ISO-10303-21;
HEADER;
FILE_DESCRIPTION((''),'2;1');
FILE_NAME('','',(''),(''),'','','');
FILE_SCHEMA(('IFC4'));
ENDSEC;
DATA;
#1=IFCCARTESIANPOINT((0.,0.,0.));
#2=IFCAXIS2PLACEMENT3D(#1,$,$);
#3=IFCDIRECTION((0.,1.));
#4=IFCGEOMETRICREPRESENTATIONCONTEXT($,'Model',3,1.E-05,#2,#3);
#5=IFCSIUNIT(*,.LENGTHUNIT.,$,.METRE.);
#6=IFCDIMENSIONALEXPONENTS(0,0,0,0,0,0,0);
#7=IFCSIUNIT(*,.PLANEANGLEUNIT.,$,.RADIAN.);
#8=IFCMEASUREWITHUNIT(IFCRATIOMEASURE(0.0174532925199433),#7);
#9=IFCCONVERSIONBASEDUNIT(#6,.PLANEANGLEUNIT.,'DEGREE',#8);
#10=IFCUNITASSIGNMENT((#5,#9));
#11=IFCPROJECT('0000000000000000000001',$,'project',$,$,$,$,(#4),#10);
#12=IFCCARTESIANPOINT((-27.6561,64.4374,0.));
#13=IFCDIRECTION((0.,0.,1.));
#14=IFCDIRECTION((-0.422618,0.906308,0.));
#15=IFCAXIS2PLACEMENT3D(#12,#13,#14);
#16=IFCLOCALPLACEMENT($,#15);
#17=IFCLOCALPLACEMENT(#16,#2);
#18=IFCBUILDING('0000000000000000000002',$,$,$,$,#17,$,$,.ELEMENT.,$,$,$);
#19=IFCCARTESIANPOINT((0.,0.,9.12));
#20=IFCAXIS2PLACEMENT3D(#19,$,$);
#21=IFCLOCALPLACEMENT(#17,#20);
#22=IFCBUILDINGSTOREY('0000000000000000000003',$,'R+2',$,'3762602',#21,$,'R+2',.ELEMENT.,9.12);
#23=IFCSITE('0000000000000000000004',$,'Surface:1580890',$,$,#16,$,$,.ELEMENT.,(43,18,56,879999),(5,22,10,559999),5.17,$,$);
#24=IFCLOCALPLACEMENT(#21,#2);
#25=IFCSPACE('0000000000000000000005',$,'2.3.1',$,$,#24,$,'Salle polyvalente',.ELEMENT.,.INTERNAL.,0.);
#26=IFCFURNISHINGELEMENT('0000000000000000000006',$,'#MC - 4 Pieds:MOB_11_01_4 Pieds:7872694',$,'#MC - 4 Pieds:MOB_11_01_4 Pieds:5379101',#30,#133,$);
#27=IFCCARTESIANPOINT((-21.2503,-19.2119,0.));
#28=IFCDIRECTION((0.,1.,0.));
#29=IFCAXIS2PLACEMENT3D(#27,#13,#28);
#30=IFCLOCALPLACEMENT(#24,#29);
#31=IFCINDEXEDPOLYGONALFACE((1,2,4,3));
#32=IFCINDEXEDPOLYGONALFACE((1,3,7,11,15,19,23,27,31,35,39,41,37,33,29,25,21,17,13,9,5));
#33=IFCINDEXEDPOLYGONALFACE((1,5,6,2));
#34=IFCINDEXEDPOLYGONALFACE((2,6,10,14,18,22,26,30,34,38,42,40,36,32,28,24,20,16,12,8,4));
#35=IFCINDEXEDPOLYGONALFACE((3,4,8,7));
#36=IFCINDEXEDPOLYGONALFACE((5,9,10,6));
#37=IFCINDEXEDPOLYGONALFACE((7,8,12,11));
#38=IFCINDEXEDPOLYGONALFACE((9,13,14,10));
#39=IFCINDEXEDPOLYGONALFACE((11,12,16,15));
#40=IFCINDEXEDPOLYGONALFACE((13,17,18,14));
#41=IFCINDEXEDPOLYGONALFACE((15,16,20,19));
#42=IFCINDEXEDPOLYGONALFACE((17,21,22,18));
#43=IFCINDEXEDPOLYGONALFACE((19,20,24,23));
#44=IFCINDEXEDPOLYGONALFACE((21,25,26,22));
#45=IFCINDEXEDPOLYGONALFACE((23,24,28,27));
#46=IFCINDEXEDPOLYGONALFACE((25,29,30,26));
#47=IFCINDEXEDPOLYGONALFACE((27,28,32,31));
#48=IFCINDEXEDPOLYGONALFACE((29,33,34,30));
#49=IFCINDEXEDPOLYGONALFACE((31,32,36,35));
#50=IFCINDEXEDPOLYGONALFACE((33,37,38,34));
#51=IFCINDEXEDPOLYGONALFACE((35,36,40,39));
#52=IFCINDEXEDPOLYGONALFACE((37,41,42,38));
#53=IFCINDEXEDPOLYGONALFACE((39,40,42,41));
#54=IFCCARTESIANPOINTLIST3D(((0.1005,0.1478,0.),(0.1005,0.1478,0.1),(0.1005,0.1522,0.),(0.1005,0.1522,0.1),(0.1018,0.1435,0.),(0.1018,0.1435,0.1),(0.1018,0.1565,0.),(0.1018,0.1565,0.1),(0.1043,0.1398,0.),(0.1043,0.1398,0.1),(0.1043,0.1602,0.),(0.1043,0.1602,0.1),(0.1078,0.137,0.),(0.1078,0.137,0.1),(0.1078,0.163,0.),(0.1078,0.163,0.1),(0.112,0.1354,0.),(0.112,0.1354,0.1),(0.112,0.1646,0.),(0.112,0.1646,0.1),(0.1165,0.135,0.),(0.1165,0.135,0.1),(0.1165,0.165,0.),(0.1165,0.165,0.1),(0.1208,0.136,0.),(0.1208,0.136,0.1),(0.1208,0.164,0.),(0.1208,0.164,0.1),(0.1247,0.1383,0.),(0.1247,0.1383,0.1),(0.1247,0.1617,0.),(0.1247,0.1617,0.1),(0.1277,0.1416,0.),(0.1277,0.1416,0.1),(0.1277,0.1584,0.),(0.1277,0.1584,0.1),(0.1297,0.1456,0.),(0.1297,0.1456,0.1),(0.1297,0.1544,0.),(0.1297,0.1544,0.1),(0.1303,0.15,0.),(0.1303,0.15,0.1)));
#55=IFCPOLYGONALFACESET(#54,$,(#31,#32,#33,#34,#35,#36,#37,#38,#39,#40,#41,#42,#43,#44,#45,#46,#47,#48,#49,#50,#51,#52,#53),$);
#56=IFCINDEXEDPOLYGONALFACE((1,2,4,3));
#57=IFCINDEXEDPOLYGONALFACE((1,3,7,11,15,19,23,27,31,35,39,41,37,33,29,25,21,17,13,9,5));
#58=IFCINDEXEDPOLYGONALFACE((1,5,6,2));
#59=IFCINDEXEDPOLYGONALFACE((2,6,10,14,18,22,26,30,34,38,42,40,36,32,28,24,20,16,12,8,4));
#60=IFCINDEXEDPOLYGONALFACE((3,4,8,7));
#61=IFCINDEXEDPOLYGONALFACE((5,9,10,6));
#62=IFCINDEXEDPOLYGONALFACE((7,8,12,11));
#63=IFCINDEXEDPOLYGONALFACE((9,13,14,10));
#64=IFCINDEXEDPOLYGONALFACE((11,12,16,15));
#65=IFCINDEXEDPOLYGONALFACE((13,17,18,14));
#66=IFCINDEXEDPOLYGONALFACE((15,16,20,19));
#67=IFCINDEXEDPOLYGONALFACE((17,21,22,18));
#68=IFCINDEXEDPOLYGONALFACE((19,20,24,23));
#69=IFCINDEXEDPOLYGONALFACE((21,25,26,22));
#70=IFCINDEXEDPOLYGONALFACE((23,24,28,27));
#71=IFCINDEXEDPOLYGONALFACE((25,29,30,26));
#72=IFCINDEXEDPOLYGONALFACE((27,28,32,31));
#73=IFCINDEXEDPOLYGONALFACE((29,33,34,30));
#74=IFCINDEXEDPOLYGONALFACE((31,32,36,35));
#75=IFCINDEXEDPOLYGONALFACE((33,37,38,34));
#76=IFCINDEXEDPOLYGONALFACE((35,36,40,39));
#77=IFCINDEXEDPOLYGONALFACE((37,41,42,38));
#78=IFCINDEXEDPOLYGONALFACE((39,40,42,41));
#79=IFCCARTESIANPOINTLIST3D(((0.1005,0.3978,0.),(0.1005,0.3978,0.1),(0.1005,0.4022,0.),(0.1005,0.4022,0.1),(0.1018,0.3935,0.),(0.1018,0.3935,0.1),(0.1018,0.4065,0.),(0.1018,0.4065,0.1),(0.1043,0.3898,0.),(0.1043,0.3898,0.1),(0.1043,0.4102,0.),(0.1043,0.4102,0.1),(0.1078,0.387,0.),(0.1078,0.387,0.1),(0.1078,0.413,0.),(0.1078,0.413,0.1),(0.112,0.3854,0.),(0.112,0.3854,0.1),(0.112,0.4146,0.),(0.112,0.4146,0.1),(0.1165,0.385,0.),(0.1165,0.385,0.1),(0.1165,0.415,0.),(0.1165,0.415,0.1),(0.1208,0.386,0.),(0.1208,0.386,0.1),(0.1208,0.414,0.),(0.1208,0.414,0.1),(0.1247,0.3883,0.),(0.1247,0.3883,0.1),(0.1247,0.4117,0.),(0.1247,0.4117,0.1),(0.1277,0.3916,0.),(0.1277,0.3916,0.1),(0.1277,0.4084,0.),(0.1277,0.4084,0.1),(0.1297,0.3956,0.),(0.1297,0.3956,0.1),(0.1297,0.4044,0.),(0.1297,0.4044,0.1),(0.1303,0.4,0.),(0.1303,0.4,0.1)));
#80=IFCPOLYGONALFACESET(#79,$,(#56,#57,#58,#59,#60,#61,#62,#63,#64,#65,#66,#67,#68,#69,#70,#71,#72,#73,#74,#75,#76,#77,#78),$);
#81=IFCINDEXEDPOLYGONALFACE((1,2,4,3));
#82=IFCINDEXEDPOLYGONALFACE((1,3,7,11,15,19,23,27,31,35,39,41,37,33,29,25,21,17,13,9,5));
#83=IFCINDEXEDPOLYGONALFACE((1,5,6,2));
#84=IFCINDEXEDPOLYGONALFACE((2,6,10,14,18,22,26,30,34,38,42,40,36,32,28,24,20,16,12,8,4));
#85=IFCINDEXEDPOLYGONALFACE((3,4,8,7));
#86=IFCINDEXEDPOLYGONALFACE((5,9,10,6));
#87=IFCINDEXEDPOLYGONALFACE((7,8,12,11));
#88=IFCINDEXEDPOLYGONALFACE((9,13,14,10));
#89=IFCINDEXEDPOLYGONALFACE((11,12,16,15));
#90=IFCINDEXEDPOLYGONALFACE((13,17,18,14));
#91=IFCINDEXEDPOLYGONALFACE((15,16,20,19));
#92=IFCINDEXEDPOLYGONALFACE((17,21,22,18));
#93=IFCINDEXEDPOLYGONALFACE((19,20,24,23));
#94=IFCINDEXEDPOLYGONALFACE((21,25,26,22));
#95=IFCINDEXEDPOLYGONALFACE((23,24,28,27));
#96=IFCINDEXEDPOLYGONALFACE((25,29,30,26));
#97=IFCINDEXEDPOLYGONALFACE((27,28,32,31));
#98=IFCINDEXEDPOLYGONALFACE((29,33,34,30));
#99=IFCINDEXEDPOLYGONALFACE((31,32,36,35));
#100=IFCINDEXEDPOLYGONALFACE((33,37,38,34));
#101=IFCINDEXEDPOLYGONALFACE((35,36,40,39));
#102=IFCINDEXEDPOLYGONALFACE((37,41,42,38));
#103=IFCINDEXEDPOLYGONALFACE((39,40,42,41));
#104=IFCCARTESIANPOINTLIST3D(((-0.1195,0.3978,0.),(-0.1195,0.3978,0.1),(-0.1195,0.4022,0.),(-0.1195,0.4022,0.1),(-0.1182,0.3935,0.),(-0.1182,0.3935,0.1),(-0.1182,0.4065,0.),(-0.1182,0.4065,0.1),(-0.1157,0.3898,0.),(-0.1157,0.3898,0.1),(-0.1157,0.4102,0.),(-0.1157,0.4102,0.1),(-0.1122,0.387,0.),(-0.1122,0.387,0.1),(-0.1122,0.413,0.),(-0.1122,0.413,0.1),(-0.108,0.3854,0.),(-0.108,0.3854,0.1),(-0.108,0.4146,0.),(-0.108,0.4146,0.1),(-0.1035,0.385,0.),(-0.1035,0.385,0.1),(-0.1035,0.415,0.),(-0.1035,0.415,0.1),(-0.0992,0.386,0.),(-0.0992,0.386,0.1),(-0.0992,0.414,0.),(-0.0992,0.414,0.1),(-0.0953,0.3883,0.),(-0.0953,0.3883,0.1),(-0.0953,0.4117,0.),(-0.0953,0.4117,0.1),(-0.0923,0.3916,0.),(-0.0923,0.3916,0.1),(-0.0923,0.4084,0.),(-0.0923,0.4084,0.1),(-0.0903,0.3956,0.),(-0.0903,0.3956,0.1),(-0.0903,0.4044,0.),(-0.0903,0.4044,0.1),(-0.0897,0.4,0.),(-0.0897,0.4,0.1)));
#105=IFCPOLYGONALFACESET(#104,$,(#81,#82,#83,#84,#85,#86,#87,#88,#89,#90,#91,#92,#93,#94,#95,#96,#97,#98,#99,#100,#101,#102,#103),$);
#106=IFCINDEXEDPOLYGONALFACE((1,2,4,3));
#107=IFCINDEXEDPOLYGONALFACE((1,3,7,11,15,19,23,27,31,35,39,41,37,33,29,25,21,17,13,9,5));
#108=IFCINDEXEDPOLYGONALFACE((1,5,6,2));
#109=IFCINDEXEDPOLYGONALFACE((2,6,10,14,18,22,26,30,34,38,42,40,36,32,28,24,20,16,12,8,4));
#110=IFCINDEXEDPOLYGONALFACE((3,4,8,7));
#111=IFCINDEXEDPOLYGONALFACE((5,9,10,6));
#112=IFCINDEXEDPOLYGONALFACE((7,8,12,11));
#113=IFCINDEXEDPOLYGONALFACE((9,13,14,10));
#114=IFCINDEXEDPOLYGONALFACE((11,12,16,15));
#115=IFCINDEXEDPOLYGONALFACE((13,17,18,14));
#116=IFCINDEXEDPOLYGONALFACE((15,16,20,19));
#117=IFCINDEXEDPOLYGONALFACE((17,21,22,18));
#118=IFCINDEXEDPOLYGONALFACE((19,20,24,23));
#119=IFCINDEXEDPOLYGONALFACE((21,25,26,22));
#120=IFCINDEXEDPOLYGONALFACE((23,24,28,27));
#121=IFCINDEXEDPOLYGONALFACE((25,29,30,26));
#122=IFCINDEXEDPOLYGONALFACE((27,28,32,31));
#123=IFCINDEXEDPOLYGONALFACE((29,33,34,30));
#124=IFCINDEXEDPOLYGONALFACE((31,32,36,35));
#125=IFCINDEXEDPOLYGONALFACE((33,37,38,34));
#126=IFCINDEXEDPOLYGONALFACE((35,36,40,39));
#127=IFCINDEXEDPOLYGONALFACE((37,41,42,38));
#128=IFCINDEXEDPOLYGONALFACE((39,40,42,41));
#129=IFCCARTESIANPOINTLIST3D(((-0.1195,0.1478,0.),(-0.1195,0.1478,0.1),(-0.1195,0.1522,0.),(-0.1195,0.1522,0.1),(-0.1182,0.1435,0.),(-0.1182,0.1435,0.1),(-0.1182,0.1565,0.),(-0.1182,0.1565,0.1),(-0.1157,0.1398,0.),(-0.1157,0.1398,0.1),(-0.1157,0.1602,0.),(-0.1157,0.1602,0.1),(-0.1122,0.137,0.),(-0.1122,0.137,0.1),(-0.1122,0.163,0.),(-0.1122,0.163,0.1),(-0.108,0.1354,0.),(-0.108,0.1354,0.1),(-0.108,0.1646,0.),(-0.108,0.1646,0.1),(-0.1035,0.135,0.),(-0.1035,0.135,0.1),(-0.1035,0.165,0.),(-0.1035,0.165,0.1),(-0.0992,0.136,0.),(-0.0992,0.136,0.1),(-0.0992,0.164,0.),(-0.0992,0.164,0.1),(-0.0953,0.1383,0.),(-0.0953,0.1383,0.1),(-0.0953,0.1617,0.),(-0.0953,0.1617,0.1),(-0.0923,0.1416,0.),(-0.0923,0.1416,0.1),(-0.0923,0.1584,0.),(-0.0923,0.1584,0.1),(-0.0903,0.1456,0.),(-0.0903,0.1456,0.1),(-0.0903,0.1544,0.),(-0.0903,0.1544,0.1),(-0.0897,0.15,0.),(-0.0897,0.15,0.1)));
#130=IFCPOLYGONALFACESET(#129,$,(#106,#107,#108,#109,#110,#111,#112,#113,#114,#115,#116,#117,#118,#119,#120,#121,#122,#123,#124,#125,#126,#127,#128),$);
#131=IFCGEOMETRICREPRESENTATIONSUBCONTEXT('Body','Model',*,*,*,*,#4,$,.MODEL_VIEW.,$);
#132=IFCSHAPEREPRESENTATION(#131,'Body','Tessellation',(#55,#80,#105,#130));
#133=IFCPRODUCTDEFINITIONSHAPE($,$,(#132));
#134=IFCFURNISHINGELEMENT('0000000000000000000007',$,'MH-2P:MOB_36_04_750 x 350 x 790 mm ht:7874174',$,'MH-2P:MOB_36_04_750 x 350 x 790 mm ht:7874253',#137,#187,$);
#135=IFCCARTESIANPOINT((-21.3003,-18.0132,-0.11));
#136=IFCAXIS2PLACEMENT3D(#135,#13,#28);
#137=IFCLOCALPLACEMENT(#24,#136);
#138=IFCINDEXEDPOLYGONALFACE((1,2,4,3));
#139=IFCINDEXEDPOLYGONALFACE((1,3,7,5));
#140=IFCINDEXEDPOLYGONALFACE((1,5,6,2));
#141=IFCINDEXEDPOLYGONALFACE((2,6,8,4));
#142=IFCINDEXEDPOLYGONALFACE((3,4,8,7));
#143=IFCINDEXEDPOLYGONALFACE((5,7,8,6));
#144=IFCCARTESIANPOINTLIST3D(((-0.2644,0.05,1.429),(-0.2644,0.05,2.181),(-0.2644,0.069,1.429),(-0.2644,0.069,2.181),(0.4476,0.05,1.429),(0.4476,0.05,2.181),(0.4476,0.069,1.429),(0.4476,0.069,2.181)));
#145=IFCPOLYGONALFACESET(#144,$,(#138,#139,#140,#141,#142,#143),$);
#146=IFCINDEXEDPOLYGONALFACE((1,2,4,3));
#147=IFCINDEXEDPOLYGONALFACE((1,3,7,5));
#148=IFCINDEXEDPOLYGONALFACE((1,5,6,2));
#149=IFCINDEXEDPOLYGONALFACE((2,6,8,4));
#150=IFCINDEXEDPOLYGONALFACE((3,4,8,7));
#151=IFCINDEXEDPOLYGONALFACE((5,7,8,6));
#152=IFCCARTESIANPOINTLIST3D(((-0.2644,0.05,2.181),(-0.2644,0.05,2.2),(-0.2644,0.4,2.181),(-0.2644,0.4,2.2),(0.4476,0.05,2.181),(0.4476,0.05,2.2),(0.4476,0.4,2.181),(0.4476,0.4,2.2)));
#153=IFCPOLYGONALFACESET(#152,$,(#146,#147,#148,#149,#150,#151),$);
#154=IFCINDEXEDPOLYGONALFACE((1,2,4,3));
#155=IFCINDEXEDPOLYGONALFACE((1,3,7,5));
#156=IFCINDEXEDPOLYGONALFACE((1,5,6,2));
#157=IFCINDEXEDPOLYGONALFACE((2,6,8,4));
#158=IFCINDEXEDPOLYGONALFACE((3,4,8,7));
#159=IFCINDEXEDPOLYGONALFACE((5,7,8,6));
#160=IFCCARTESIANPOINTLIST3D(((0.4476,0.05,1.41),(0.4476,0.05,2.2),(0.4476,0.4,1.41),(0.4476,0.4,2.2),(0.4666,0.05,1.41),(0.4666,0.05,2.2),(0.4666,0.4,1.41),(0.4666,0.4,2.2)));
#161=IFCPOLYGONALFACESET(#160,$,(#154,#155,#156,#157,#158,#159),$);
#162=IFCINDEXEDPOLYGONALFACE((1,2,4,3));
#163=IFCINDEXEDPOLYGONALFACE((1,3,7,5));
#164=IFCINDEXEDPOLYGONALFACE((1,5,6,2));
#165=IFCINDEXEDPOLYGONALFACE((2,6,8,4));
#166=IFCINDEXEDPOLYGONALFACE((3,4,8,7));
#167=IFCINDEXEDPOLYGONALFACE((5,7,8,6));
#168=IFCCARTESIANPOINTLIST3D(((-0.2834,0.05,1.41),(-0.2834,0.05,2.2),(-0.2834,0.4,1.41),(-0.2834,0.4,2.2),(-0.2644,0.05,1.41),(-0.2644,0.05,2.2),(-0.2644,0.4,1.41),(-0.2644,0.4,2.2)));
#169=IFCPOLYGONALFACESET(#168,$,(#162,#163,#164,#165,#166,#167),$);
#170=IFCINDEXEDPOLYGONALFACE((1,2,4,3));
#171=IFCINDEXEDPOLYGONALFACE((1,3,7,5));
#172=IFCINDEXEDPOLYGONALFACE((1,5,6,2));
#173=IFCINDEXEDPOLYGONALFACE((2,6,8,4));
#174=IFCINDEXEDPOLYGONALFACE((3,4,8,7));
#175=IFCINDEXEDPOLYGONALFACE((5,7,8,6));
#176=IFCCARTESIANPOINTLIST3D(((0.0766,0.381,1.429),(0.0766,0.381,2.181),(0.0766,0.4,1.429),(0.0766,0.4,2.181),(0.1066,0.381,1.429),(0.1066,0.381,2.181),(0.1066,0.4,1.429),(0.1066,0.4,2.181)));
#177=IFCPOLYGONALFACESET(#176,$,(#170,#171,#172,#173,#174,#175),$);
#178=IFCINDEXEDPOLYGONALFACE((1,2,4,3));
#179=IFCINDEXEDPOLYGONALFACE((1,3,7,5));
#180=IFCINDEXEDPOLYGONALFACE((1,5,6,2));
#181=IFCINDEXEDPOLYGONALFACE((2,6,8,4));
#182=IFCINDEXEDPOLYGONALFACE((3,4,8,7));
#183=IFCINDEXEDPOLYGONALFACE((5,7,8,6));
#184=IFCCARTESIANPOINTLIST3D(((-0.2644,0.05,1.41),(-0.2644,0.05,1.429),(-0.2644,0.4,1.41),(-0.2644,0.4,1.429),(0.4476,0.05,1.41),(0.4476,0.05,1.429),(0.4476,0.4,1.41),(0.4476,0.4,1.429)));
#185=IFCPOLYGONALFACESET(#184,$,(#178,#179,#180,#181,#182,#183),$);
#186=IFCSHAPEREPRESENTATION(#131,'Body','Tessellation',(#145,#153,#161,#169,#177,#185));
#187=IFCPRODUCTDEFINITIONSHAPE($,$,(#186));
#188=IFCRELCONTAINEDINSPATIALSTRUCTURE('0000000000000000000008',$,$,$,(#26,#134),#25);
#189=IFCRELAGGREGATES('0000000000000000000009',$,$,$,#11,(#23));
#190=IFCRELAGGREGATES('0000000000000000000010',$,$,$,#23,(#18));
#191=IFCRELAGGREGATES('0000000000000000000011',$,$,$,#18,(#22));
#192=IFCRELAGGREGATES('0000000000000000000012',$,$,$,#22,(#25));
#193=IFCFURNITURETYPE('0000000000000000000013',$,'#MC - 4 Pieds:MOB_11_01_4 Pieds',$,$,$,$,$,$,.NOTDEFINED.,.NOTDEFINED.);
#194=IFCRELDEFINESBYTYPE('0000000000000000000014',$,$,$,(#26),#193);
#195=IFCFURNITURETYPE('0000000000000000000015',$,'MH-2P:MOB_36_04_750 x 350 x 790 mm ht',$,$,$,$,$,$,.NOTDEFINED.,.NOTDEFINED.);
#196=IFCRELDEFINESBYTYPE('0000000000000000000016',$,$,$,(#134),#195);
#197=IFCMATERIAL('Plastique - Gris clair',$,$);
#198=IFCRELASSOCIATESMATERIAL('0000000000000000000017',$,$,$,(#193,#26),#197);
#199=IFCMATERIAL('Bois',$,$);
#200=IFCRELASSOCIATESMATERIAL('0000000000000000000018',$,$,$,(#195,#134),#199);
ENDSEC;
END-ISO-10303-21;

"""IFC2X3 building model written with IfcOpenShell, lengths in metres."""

from ifc_helpers import new_model, entity, si_unit, converted_unit, direction, frame, frame_2d, origin, origin_2d_with_axis, place, context, subcontext, project, spatial, rectangle, circle, extrude, source, transform, mapped, material, type_object, type_shapes, element, save


model = new_model("IFC2X3")

# Units and contexts
model_context = context("Model", 3, precision=1e-05, world=origin(), true_north=direction((0.0, 1.0)))
body_context = subcontext(model_context, "Body", "Model", "MODEL_VIEW")
ifc_project = project(units=[si_unit("LENGTHUNIT", "METRE"), converted_unit("PLANEANGLEUNIT", "DEGREE", entity("IfcRatioMeasure", 0.0174532925199433), si_unit("PLANEANGLEUNIT", "RADIAN"), dimensions=[0, 0, 0, 0, 0, 0, 0])], contexts=[model_context])

# Site, building, storey
site_placement = place(None, frame((-27.6561, 64.4374, 0.0), z_axis=(0.0, 0.0, 1.0), x_axis=(-0.422618, 0.906308, 0.0)))
site = spatial("IfcSite", under=ifc_project, at=site_placement, Name="Surface:1580890", CompositionType="ELEMENT", RefLatitude=(43, 18, 56, 879999), RefLongitude=(5, 22, 10, 559999), RefElevation=5.17)
building_placement = place(site_placement, origin())
building = spatial("IfcBuilding", under=site, at=building_placement, CompositionType="ELEMENT")
storey_placement = place(building_placement, frame((0.0, 0.0, 9.12)))
storey = spatial("IfcBuildingStorey", under=building, at=storey_placement, Name="R+2", ObjectType="3762602", LongName="R+2", CompositionType="ELEMENT", Elevation=9.12)

# Shared definitions
space_placement = place(storey_placement, origin())
space = spatial("IfcSpace", under=storey, at=space_placement, Name="2.3.1", LongName="Salle polyvalente", CompositionType="ELEMENT", InteriorOrExteriorSpace="INTERNAL", ElevationWithFlooring=0.0)

# Furnishing elements
ifc_material_1 = material(Name="Bois")
ifc_material_2 = material(Name="Plastique - Gris clair")
furniture_type_1 = type_object("IfcFurnitureType", Name="#MC - 4 Pieds:MOB_11_01_4 Pieds", material=ifc_material_2)
shared_shape_1 = source(origin(), body_context, "Body", "SweptSolid", [
    extrude(circle(Radius=0.015, at=frame_2d((0.0, 0.0), x_axis=(1.0, 0.0))), frame((0.1153, 0.15, 0.0)), (0.0, 0.0, 1.0), 0.1),
    extrude(circle(Radius=0.015, at=frame_2d((0.0, 0.0), x_axis=(1.0, 0.0))), frame((0.1153, 0.4, 0.0)), (0.0, 0.0, 1.0), 0.1),
    extrude(circle(Radius=0.015, at=origin_2d_with_axis()), frame((-0.1047, 0.4, 0.0)), (0.0, 0.0, 1.0), 0.1),
    extrude(circle(Radius=0.015, at=frame_2d((0.0, 0.0), x_axis=(1.0, 0.0))), frame((-0.1047, 0.15, 0.0)), (0.0, 0.0, 1.0), 0.1),
])
type_shapes(furniture_type_1, [shared_shape_1])
furnishing_1_placement = place(space_placement, frame((-21.2503, -19.2119, 0.0), z_axis=(0.0, 0.0, 1.0), x_axis=(0.0, 1.0, 0.0)))
element("IfcFurnishingElement", 1, at=furnishing_1_placement, inside=space, type_object=furniture_type_1, material=ifc_material_2, Name="#MC - 4 Pieds:MOB_11_01_4 Pieds:7872694", ObjectType="#MC - 4 Pieds:MOB_11_01_4 Pieds:5379101", context=body_context, shape_type="MappedRepresentation", body=[
    mapped(shared_shape_1, transform((0.0, 0.0, 0.0), scale=1.0)),
])
furniture_type_2 = type_object("IfcFurnitureType", Name="MH-2P:MOB_36_04_750 x 350 x 790 mm ht", material=ifc_material_1)
shared_shape_2 = source(origin(), body_context, "Body", "SweptSolid", [
    extrude(rectangle(XDim=0.019, YDim=0.712, at=origin_2d_with_axis()), frame((0.0916, 0.0595, 1.429), z_axis=(0.0, 0.0, 1.0), x_axis=(0.0, 1.0, 0.0)), (0.0, 0.0, 1.0), 0.752),
    extrude(rectangle(XDim=0.35, YDim=0.712, at=frame_2d((0.0, 0.0), x_axis=(1.0, 0.0))), frame((0.0916, 0.225, 2.181), z_axis=(0.0, 0.0, 1.0), x_axis=(0.0, 1.0, 0.0)), (0.0, 0.0, 1.0), 0.019),
    extrude(rectangle(XDim=0.35, YDim=0.019, at=origin_2d_with_axis()), frame((0.4571, 0.225, 1.41), z_axis=(0.0, 0.0, 1.0), x_axis=(0.0, 1.0, 0.0)), (0.0, 0.0, 1.0), 0.79),
    extrude(rectangle(XDim=0.35, YDim=0.019, at=origin_2d_with_axis()), frame((-0.2739, 0.225, 1.41), z_axis=(0.0, 0.0, 1.0), x_axis=(0.0, 1.0, 0.0)), (0.0, 0.0, 1.0), 0.79),
    extrude(rectangle(XDim=0.019, YDim=0.03, at=frame_2d((0.0, 0.0), x_axis=(1.0, 0.0))), frame((0.0916, 0.3905, 1.429), z_axis=(0.0, 0.0, 1.0), x_axis=(0.0, 1.0, 0.0)), (0.0, 0.0, 1.0), 0.752),
    extrude(rectangle(XDim=0.35, YDim=0.712, at=origin_2d_with_axis()), frame((0.0916, 0.225, 1.41), z_axis=(0.0, 0.0, 1.0), x_axis=(0.0, 1.0, 0.0)), (0.0, 0.0, 1.0), 0.019),
])
type_shapes(furniture_type_2, [shared_shape_2])
for number, where, z_axis, x_axis, name in (
    (2, (-21.3003, -18.0132, -0.11), (0.0, 0.0, 1.0), (0.0, 1.0, 0.0), "MH-2P:MOB_36_04_750 x 350 x 790 mm ht:7874174"),
):
    element("IfcFurnishingElement", number, at=place(space_placement, frame(where, z_axis=z_axis, x_axis=x_axis)), inside=space, type_object=furniture_type_2, material=ifc_material_1, Name=name, ObjectType="MH-2P:MOB_36_04_750 x 350 x 790 mm ht:7874253", context=body_context, shape_type="MappedRepresentation", body=[
        mapped(shared_shape_2, transform((0.0, 0.0, 0.0), scale=1.0)),
    ])

save(model, "model.ifc")
